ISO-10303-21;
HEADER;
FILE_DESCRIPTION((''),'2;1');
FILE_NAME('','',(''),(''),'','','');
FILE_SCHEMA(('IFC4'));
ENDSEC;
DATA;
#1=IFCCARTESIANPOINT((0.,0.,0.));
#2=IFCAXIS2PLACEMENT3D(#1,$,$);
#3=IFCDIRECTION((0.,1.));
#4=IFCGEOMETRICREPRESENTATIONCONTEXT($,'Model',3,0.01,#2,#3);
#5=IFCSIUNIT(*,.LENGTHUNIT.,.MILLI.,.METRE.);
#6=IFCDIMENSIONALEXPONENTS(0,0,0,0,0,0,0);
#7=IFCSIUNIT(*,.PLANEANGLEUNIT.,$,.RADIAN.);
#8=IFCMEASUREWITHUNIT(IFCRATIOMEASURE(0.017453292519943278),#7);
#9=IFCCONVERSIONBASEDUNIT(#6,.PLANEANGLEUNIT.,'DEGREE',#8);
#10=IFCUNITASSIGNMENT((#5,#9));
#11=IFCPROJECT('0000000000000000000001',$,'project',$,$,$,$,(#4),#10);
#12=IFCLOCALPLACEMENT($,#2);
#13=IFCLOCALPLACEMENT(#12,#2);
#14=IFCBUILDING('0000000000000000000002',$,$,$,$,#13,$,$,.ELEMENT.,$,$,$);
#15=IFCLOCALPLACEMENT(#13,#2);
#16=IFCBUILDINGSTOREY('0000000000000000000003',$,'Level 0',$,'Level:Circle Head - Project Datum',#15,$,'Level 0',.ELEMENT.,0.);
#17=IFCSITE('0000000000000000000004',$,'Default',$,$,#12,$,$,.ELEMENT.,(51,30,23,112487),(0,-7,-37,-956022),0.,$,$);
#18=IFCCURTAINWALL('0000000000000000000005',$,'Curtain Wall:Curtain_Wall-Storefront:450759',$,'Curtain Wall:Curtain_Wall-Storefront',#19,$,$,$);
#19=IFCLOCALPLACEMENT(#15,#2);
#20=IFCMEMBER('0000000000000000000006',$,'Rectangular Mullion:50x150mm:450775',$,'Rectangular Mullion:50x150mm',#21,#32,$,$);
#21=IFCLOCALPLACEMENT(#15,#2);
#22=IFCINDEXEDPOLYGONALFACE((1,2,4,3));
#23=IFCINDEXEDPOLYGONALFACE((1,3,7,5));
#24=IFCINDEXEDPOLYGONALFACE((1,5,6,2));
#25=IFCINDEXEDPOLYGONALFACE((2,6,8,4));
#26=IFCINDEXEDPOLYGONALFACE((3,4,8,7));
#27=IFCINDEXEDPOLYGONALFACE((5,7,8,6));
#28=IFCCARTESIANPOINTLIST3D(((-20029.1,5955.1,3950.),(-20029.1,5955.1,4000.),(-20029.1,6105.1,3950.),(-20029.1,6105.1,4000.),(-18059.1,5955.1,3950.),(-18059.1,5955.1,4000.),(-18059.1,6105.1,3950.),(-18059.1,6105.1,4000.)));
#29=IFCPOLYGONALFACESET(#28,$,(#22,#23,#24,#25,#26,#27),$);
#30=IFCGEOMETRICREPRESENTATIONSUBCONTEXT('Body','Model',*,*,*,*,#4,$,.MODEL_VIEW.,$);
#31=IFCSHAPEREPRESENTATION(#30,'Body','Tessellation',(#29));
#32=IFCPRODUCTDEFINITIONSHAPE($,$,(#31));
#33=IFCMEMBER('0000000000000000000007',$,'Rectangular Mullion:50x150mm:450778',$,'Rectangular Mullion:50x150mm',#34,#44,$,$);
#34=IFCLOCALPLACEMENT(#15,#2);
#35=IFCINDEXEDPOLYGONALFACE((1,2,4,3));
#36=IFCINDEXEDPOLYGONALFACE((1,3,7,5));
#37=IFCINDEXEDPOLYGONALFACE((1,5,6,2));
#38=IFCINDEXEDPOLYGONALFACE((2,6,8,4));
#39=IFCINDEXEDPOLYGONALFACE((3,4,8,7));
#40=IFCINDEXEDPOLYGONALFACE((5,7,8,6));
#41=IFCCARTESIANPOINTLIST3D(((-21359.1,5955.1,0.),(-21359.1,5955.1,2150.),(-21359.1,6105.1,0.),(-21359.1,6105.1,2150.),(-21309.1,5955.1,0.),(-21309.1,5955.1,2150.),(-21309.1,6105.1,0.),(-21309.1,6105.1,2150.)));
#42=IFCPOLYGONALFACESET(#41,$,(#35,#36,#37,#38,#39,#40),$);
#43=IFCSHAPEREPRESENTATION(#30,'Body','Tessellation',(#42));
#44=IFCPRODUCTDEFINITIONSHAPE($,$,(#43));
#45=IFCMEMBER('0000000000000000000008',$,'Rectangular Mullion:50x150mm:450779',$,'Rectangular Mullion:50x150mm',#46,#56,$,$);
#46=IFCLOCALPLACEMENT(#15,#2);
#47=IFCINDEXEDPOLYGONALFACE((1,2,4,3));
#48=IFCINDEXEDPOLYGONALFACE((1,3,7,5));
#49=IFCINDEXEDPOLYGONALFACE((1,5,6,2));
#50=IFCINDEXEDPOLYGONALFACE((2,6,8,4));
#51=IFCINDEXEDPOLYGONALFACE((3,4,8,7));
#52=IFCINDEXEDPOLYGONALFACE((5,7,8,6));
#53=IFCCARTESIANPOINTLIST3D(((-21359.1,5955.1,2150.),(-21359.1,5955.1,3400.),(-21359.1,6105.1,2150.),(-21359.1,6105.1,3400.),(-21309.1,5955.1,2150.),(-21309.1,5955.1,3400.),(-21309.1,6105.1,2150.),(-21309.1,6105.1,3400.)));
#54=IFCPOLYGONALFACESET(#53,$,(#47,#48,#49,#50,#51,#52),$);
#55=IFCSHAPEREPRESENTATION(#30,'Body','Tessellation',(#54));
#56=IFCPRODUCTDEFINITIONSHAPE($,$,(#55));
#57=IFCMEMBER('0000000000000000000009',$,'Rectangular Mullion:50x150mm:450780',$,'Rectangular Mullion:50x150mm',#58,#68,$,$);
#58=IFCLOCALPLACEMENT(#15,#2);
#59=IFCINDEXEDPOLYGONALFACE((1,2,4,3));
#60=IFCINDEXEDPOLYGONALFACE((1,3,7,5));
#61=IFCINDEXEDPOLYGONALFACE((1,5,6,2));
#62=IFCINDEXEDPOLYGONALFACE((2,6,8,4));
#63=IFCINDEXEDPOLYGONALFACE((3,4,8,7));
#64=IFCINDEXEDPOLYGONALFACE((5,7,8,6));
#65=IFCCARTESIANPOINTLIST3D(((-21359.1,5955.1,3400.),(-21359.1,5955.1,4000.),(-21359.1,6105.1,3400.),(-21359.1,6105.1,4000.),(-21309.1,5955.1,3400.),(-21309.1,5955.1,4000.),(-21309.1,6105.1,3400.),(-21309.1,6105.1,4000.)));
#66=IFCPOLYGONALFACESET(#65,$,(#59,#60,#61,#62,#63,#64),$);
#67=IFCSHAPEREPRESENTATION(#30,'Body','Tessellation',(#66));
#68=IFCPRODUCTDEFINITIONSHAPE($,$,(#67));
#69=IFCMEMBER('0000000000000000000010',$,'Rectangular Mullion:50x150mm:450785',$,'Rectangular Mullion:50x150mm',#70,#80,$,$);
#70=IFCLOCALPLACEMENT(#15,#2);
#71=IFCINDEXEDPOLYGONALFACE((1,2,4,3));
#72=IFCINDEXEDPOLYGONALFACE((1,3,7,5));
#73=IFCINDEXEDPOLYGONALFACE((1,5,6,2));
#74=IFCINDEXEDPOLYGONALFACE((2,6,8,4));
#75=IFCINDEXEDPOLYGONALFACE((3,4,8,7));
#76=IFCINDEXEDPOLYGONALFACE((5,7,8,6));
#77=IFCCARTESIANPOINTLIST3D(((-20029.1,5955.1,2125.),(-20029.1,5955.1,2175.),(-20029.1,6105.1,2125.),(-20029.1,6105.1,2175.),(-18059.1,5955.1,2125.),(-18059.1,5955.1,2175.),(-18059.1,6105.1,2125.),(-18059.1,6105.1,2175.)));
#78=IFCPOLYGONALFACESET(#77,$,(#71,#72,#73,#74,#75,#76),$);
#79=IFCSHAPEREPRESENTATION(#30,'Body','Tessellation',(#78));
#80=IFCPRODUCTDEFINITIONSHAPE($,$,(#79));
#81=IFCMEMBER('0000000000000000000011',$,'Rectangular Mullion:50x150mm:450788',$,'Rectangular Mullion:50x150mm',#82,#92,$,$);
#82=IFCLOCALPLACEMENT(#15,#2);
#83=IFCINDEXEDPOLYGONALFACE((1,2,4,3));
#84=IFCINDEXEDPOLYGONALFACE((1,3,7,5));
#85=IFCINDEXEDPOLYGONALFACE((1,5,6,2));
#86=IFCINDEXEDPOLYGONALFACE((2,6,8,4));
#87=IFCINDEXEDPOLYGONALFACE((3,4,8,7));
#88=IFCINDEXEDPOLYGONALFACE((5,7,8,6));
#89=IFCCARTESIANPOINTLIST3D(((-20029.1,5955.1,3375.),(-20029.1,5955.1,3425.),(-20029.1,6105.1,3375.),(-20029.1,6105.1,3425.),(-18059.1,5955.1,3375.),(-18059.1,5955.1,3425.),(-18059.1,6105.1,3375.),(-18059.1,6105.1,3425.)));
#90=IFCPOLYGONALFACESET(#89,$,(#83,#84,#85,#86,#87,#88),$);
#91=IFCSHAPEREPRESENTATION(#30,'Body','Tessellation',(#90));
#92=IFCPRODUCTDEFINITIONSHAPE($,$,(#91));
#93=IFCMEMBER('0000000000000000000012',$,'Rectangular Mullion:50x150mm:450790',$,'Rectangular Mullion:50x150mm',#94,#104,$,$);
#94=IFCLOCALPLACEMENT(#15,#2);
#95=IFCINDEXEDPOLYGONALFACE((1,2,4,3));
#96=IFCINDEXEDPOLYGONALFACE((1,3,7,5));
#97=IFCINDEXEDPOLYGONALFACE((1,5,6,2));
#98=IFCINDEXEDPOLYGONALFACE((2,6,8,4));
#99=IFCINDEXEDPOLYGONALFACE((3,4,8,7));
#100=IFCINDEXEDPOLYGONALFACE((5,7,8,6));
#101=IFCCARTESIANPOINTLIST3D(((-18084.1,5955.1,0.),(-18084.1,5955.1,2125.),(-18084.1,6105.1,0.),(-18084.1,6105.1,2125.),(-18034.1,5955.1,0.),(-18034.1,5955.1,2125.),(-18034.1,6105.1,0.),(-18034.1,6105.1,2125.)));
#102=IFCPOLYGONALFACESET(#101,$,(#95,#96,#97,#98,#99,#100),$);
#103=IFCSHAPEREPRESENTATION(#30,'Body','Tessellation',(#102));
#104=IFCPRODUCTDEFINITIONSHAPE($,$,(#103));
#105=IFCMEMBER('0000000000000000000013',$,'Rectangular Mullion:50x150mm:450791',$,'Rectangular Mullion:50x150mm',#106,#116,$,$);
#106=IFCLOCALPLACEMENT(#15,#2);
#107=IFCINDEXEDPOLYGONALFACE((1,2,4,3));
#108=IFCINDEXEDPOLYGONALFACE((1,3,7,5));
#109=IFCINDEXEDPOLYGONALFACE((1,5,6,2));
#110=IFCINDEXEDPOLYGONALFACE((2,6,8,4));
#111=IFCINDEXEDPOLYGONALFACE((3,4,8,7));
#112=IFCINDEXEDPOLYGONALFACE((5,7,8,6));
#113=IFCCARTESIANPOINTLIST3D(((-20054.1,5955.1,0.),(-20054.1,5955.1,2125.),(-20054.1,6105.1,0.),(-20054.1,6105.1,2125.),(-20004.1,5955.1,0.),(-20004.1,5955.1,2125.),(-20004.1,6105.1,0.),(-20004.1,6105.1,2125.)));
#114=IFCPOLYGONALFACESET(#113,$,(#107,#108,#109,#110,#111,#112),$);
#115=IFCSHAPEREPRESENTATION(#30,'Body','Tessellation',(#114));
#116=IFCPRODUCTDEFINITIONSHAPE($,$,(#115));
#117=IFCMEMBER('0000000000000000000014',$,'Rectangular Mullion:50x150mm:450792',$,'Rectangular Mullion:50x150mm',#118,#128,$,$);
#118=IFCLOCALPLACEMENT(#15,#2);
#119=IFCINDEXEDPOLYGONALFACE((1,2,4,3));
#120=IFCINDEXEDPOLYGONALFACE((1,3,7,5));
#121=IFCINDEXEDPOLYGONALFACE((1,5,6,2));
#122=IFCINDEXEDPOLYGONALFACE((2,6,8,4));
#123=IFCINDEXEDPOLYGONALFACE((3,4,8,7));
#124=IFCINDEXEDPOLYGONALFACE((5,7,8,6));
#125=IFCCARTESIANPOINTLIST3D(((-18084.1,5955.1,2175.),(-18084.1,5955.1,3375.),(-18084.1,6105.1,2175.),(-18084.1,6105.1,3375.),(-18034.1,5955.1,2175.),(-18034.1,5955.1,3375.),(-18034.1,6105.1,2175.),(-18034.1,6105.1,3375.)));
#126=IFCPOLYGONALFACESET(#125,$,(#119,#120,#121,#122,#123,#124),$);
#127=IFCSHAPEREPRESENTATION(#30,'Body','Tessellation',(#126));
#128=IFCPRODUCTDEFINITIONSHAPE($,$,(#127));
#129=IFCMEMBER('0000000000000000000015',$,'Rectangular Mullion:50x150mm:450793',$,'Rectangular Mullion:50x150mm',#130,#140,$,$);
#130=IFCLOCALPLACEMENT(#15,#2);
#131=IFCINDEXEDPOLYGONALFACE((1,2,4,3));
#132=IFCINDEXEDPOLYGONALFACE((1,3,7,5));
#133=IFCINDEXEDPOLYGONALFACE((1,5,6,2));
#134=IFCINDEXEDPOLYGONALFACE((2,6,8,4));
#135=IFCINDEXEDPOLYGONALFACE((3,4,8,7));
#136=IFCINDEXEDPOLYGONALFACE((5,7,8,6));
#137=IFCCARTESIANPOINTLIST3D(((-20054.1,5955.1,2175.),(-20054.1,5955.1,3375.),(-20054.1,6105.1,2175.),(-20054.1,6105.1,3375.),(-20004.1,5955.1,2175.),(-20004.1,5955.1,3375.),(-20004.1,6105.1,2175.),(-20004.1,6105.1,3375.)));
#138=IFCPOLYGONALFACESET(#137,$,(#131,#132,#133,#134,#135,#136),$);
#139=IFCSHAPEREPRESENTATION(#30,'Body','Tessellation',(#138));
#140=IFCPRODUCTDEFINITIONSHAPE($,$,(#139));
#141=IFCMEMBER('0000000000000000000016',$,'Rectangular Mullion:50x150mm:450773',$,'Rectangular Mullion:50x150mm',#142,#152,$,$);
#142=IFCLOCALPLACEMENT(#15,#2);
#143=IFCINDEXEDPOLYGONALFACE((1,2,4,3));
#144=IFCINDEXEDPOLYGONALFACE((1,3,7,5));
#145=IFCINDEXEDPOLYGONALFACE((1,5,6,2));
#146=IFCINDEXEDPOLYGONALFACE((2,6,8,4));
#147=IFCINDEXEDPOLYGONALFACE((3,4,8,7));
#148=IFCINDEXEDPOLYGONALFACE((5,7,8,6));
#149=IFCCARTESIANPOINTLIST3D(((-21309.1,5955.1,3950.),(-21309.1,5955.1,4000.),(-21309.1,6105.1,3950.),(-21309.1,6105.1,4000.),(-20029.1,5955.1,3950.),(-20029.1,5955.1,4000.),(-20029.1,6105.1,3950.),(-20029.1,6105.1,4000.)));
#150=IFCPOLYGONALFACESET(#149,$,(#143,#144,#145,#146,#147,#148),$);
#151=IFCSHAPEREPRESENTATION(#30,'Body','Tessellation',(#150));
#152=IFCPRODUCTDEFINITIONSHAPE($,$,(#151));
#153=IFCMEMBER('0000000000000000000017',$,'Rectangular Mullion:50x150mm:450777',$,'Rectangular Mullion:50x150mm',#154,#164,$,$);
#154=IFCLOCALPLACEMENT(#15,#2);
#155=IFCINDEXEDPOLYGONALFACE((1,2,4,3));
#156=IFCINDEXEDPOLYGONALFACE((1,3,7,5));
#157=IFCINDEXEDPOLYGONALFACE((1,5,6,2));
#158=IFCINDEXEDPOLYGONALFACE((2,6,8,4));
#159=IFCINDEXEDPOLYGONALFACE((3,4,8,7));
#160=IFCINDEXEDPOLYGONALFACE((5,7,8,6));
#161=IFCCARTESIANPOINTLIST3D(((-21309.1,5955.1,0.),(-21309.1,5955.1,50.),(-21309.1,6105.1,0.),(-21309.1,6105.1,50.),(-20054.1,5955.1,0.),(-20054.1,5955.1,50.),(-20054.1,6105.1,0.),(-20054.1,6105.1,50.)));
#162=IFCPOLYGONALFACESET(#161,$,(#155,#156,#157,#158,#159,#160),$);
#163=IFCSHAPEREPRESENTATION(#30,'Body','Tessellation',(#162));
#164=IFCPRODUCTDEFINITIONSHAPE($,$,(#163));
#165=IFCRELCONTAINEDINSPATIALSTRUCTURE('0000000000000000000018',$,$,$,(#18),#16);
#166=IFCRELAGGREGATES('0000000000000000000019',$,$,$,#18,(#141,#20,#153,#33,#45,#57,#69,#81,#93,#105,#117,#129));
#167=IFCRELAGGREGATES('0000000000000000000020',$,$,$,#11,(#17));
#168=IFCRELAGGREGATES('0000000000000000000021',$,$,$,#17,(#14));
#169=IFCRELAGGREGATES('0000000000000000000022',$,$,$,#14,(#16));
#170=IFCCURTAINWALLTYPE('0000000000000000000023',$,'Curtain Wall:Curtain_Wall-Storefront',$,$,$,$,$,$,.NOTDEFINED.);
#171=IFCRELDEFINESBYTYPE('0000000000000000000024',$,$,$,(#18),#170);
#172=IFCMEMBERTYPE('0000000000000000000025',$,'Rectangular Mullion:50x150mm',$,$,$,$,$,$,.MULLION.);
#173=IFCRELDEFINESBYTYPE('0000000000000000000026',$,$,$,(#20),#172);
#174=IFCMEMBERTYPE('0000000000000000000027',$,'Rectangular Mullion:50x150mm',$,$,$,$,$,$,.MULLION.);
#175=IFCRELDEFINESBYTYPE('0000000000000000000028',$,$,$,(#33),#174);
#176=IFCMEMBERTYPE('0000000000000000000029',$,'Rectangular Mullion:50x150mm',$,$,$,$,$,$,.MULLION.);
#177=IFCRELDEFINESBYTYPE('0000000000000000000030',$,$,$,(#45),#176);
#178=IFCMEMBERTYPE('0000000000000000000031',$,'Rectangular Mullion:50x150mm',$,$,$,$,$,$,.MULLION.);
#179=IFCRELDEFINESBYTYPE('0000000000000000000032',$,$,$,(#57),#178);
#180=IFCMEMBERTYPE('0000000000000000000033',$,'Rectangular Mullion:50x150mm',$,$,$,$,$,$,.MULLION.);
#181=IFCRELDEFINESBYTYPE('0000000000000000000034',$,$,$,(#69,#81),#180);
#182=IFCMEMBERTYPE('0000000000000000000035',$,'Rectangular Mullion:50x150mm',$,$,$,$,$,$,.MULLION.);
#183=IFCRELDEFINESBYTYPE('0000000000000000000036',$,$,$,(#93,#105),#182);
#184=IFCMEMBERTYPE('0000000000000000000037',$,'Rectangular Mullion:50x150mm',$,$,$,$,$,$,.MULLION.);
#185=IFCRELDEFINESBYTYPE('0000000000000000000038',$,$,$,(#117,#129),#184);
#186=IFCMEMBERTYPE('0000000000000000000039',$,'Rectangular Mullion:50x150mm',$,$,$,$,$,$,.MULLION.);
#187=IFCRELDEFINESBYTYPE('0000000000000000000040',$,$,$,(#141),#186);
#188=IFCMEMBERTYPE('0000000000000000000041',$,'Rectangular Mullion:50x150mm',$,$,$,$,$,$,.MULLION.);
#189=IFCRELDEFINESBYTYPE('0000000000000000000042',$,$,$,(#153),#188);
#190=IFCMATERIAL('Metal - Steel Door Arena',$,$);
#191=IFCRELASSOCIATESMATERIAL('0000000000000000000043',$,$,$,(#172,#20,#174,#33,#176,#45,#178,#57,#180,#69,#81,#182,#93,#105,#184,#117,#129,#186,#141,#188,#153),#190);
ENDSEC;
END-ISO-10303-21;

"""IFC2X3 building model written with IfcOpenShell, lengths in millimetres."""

from ifc_helpers import new_model, entity, si_unit, converted_unit, direction, frame, origin, origin_2d_with_axis, place, context, subcontext, project, spatial, rectangle, extrude, source, transform, mapped, material, type_object, type_shapes, element, aggregate, save


model = new_model("IFC2X3")

# Units and contexts
model_context = context("Model", 3, precision=0.01, world=origin(), true_north=direction((0.0, 1.0)))
body_context = subcontext(model_context, "Body", "Model", "MODEL_VIEW")
ifc_project = project(units=[si_unit("LENGTHUNIT", "METRE", prefix="MILLI"), converted_unit("PLANEANGLEUNIT", "DEGREE", entity("IfcRatioMeasure", 0.017453292519943278), si_unit("PLANEANGLEUNIT", "RADIAN"), dimensions=[0, 0, 0, 0, 0, 0, 0])], contexts=[model_context])

# Site, building, storey
site_placement = place(None, origin())
site = spatial("IfcSite", under=ifc_project, at=site_placement, Name="Default", CompositionType="ELEMENT", RefLatitude=(51, 30, 23, 112487), RefLongitude=(0, -7, -37, -956022), RefElevation=0.0)
building_placement = place(site_placement, origin())
building = spatial("IfcBuilding", under=site, at=building_placement, CompositionType="ELEMENT")
storey_placement = place(building_placement, origin())
storey = spatial("IfcBuildingStorey", under=building, at=storey_placement, Name="Level 0", ObjectType="Level:Circle Head - Project Datum", LongName="Level 0", CompositionType="ELEMENT", Elevation=0.0)

# Curtain wall, members
curtain_wall_type = type_object("IfcCurtainWallType", Name="Curtain Wall:Curtain_Wall-Storefront", PredefinedType="NOTDEFINED")
curtain_wall_placement = place(storey_placement, origin())
curtain_wall = element("IfcCurtainWall", 1, at=curtain_wall_placement, inside=storey, type_object=curtain_wall_type, Name="Curtain Wall:Curtain_Wall-Storefront:450759", ObjectType="Curtain Wall:Curtain_Wall-Storefront")
ifc_material_1 = material(Name="Metal - Steel Door Arena")
member_type_1 = type_object("IfcMemberType", Name="Rectangular Mullion:50x150mm", PredefinedType="MULLION", material=ifc_material_1)
shared_shape_1 = source(origin(), body_context, "Body", "SweptSolid", [
    extrude(rectangle(XDim=150.0, YDim=50.0, at=origin_2d_with_axis()), frame((-25.0, 0.0, -1970.0), z_axis=(0.0, 0.0, 1.0), x_axis=(0.0, -1.0, 0.0)), (0.0, 0.0, 1.0), 1970.0),
])
type_shapes(member_type_1, [shared_shape_1])
member_1_placement = place(curtain_wall_placement, frame((-20029.1, 6030.1, 4000.0), z_axis=(-1.0, 0.0, 0.0), x_axis=(0.0, 0.0, 1.0)))
member_1 = element("IfcMember", 2, at=member_1_placement, type_object=member_type_1, material=ifc_material_1, Name="Rectangular Mullion:50x150mm:450775", ObjectType="Rectangular Mullion:50x150mm", context=body_context, shape_type="MappedRepresentation", body=[
    mapped(shared_shape_1, transform((0.0, 0.0, 0.0), scale=1.0)),
])
member_type_2 = type_object("IfcMemberType", Name="Rectangular Mullion:50x150mm", PredefinedType="MULLION", material=ifc_material_1)
shared_shape_2 = source(origin(), body_context, "Body", "SweptSolid", [
    extrude(rectangle(XDim=150.0, YDim=50.0, at=origin_2d_with_axis()), frame((-25.0, 0.0, -2150.0), z_axis=(0.0, 0.0, 1.0), x_axis=(0.0, -1.0, 0.0)), (0.0, 0.0, 1.0), 2150.0),
])
type_shapes(member_type_2, [shared_shape_2])
member_2_placement = place(curtain_wall_placement, frame((-21359.1, 6030.1, 0.0), z_axis=(0.0, 0.0, -1.0), x_axis=(-1.0, 0.0, 0.0)))
member_2 = element("IfcMember", 3, at=member_2_placement, type_object=member_type_2, material=ifc_material_1, Name="Rectangular Mullion:50x150mm:450778", ObjectType="Rectangular Mullion:50x150mm", context=body_context, shape_type="MappedRepresentation", body=[
    mapped(shared_shape_2, transform((0.0, 0.0, 0.0), scale=1.0)),
])
member_type_3 = type_object("IfcMemberType", Name="Rectangular Mullion:50x150mm", PredefinedType="MULLION", material=ifc_material_1)
shared_shape_3 = source(origin(), body_context, "Body", "SweptSolid", [
    extrude(rectangle(XDim=150.0, YDim=50.0, at=origin_2d_with_axis()), frame((-25.0, 0.0, -1250.0), z_axis=(0.0, 0.0, 1.0), x_axis=(0.0, -1.0, 0.0)), (0.0, 0.0, 1.0), 1250.0),
])
type_shapes(member_type_3, [shared_shape_3])
member_3_placement = place(curtain_wall_placement, frame((-21359.1, 6030.1, 2150.0), z_axis=(0.0, 0.0, -1.0), x_axis=(-1.0, 0.0, 0.0)))
member_3 = element("IfcMember", 4, at=member_3_placement, type_object=member_type_3, material=ifc_material_1, Name="Rectangular Mullion:50x150mm:450779", ObjectType="Rectangular Mullion:50x150mm", context=body_context, shape_type="MappedRepresentation", body=[
    mapped(shared_shape_3, transform((0.0, 0.0, 0.0), scale=1.0)),
])
member_type_4 = type_object("IfcMemberType", Name="Rectangular Mullion:50x150mm", PredefinedType="MULLION", material=ifc_material_1)
shared_shape_4 = source(origin(), body_context, "Body", "SweptSolid", [
    extrude(rectangle(XDim=150.0, YDim=50.0, at=origin_2d_with_axis()), frame((-25.0, 0.0, -600.0), z_axis=(0.0, 0.0, 1.0), x_axis=(0.0, -1.0, 0.0)), (0.0, 0.0, 1.0), 600.0),
])
type_shapes(member_type_4, [shared_shape_4])
member_4_placement = place(curtain_wall_placement, frame((-21359.1, 6030.1, 3400.0), z_axis=(0.0, 0.0, -1.0), x_axis=(-1.0, 0.0, 0.0)))
member_4 = element("IfcMember", 5, at=member_4_placement, type_object=member_type_4, material=ifc_material_1, Name="Rectangular Mullion:50x150mm:450780", ObjectType="Rectangular Mullion:50x150mm", context=body_context, shape_type="MappedRepresentation", body=[
    mapped(shared_shape_4, transform((0.0, 0.0, 0.0), scale=1.0)),
])
member_type_5 = type_object("IfcMemberType", Name="Rectangular Mullion:50x150mm", PredefinedType="MULLION", material=ifc_material_1)
shared_shape_5 = source(origin(), body_context, "Body", "SweptSolid", [
    extrude(rectangle(XDim=150.0, YDim=50.0, at=origin_2d_with_axis()), frame((0.0, 0.0, -1970.0), z_axis=(0.0, 0.0, 1.0), x_axis=(0.0, -1.0, 0.0)), (0.0, 0.0, 1.0), 1970.0),
])
type_shapes(member_type_5, [shared_shape_5])
member_5_placement = place(curtain_wall_placement, frame((-20029.1, 6030.1, 2150.0), z_axis=(-1.0, 0.0, 0.0), x_axis=(0.0, 0.0, 1.0)))
member_5 = element("IfcMember", 6, at=member_5_placement, type_object=member_type_5, material=ifc_material_1, Name="Rectangular Mullion:50x150mm:450785", ObjectType="Rectangular Mullion:50x150mm", context=body_context, shape_type="MappedRepresentation", body=[
    mapped(shared_shape_5, transform((0.0, 0.0, 0.0), scale=1.0)),
])
member_6_placement = place(curtain_wall_placement, frame((-20029.1, 6030.1, 3400.0), z_axis=(-1.0, 0.0, 0.0), x_axis=(0.0, 0.0, 1.0)))
member_6 = element("IfcMember", 7, at=member_6_placement, type_object=member_type_5, material=ifc_material_1, Name="Rectangular Mullion:50x150mm:450788", ObjectType="Rectangular Mullion:50x150mm", context=body_context, shape_type="MappedRepresentation", body=[
    mapped(shared_shape_5, transform((0.0, 0.0, 0.0), scale=1.0)),
])
member_type_6 = type_object("IfcMemberType", Name="Rectangular Mullion:50x150mm", PredefinedType="MULLION", material=ifc_material_1)
shared_shape_6 = source(origin(), body_context, "Body", "SweptSolid", [
    extrude(rectangle(XDim=150.0, YDim=50.0, at=origin_2d_with_axis()), frame((0.0, 0.0, -2125.0), z_axis=(0.0, 0.0, 1.0), x_axis=(0.0, -1.0, 0.0)), (0.0, 0.0, 1.0), 2125.0),
])
type_shapes(member_type_6, [shared_shape_6])
member_7_placement = place(curtain_wall_placement, frame((-18059.1, 6030.1, 0.0), z_axis=(0.0, 0.0, -1.0), x_axis=(-1.0, 0.0, 0.0)))
member_7 = element("IfcMember", 8, at=member_7_placement, type_object=member_type_6, material=ifc_material_1, Name="Rectangular Mullion:50x150mm:450790", ObjectType="Rectangular Mullion:50x150mm", context=body_context, shape_type="MappedRepresentation", body=[
    mapped(shared_shape_6, transform((0.0, 0.0, 0.0), scale=1.0)),
])
member_8_placement = place(curtain_wall_placement, frame((-20029.1, 6030.1, 0.0), z_axis=(0.0, 0.0, -1.0), x_axis=(-1.0, 0.0, 0.0)))
member_8 = element("IfcMember", 9, at=member_8_placement, type_object=member_type_6, material=ifc_material_1, Name="Rectangular Mullion:50x150mm:450791", ObjectType="Rectangular Mullion:50x150mm", context=body_context, shape_type="MappedRepresentation", body=[
    mapped(shared_shape_6, transform((0.0, 0.0, 0.0), scale=1.0)),
])
member_type_7 = type_object("IfcMemberType", Name="Rectangular Mullion:50x150mm", PredefinedType="MULLION", material=ifc_material_1)
shared_shape_7 = source(origin(), body_context, "Body", "SweptSolid", [
    extrude(rectangle(XDim=150.0, YDim=50.0, at=origin_2d_with_axis()), frame((0.0, 0.0, -1200.0), z_axis=(0.0, 0.0, 1.0), x_axis=(0.0, -1.0, 0.0)), (0.0, 0.0, 1.0), 1200.0),
])
type_shapes(member_type_7, [shared_shape_7])
member_9_placement = place(curtain_wall_placement, frame((-18059.1, 6030.1, 2175.0), z_axis=(0.0, 0.0, -1.0), x_axis=(-1.0, 0.0, 0.0)))
member_9 = element("IfcMember", 10, at=member_9_placement, type_object=member_type_7, material=ifc_material_1, Name="Rectangular Mullion:50x150mm:450792", ObjectType="Rectangular Mullion:50x150mm", context=body_context, shape_type="MappedRepresentation", body=[
    mapped(shared_shape_7, transform((0.0, 0.0, 0.0), scale=1.0)),
])
member_10_placement = place(curtain_wall_placement, frame((-20029.1, 6030.1, 2175.0), z_axis=(0.0, 0.0, -1.0), x_axis=(-1.0, 0.0, 0.0)))
member_10 = element("IfcMember", 11, at=member_10_placement, type_object=member_type_7, material=ifc_material_1, Name="Rectangular Mullion:50x150mm:450793", ObjectType="Rectangular Mullion:50x150mm", context=body_context, shape_type="MappedRepresentation", body=[
    mapped(shared_shape_7, transform((0.0, 0.0, 0.0), scale=1.0)),
])
member_type_8 = type_object("IfcMemberType", Name="Rectangular Mullion:50x150mm", PredefinedType="MULLION", material=ifc_material_1)
shared_shape_8 = source(origin(), body_context, "Body", "SweptSolid", [
    extrude(rectangle(XDim=150.0, YDim=50.0, at=origin_2d_with_axis()), frame((-25.0, 0.0, -1280.0), z_axis=(0.0, 0.0, 1.0), x_axis=(0.0, -1.0, 0.0)), (0.0, 0.0, 1.0), 1280.0),
])
type_shapes(member_type_8, [shared_shape_8])
member_11_placement = place(curtain_wall_placement, frame((-21309.1, 6030.1, 4000.0), z_axis=(-1.0, 0.0, 0.0), x_axis=(0.0, 0.0, 1.0)))
member_11 = element("IfcMember", 12, at=member_11_placement, type_object=member_type_8, material=ifc_material_1, Name="Rectangular Mullion:50x150mm:450773", ObjectType="Rectangular Mullion:50x150mm", context=body_context, shape_type="MappedRepresentation", body=[
    mapped(shared_shape_8, transform((0.0, 0.0, 0.0), scale=1.0)),
])
member_type_9 = type_object("IfcMemberType", Name="Rectangular Mullion:50x150mm", PredefinedType="MULLION", material=ifc_material_1)
shared_shape_9 = source(origin(), body_context, "Body", "SweptSolid", [
    extrude(rectangle(XDim=150.0, YDim=50.0, at=origin_2d_with_axis()), frame((-25.0, 0.0, -1255.0), z_axis=(0.0, 0.0, 1.0), x_axis=(0.0, -1.0, 0.0)), (0.0, 0.0, 1.0), 1255.0),
])
type_shapes(member_type_9, [shared_shape_9])
member_12_placement = place(curtain_wall_placement, frame((-20054.1, 6030.1, 0.0), z_axis=(1.0, 0.0, 0.0), x_axis=(0.0, 0.0, -1.0)))
member_12 = element("IfcMember", 13, at=member_12_placement, type_object=member_type_9, material=ifc_material_1, Name="Rectangular Mullion:50x150mm:450777", ObjectType="Rectangular Mullion:50x150mm", context=body_context, shape_type="MappedRepresentation", body=[
    mapped(shared_shape_9, transform((0.0, 0.0, 0.0), scale=1.0)),
])
aggregate(curtain_wall, [member_11, member_1, member_12, member_2, member_3, member_4, member_5, member_6, member_7, member_8, member_9, member_10])

save(model, "model.ifc")
